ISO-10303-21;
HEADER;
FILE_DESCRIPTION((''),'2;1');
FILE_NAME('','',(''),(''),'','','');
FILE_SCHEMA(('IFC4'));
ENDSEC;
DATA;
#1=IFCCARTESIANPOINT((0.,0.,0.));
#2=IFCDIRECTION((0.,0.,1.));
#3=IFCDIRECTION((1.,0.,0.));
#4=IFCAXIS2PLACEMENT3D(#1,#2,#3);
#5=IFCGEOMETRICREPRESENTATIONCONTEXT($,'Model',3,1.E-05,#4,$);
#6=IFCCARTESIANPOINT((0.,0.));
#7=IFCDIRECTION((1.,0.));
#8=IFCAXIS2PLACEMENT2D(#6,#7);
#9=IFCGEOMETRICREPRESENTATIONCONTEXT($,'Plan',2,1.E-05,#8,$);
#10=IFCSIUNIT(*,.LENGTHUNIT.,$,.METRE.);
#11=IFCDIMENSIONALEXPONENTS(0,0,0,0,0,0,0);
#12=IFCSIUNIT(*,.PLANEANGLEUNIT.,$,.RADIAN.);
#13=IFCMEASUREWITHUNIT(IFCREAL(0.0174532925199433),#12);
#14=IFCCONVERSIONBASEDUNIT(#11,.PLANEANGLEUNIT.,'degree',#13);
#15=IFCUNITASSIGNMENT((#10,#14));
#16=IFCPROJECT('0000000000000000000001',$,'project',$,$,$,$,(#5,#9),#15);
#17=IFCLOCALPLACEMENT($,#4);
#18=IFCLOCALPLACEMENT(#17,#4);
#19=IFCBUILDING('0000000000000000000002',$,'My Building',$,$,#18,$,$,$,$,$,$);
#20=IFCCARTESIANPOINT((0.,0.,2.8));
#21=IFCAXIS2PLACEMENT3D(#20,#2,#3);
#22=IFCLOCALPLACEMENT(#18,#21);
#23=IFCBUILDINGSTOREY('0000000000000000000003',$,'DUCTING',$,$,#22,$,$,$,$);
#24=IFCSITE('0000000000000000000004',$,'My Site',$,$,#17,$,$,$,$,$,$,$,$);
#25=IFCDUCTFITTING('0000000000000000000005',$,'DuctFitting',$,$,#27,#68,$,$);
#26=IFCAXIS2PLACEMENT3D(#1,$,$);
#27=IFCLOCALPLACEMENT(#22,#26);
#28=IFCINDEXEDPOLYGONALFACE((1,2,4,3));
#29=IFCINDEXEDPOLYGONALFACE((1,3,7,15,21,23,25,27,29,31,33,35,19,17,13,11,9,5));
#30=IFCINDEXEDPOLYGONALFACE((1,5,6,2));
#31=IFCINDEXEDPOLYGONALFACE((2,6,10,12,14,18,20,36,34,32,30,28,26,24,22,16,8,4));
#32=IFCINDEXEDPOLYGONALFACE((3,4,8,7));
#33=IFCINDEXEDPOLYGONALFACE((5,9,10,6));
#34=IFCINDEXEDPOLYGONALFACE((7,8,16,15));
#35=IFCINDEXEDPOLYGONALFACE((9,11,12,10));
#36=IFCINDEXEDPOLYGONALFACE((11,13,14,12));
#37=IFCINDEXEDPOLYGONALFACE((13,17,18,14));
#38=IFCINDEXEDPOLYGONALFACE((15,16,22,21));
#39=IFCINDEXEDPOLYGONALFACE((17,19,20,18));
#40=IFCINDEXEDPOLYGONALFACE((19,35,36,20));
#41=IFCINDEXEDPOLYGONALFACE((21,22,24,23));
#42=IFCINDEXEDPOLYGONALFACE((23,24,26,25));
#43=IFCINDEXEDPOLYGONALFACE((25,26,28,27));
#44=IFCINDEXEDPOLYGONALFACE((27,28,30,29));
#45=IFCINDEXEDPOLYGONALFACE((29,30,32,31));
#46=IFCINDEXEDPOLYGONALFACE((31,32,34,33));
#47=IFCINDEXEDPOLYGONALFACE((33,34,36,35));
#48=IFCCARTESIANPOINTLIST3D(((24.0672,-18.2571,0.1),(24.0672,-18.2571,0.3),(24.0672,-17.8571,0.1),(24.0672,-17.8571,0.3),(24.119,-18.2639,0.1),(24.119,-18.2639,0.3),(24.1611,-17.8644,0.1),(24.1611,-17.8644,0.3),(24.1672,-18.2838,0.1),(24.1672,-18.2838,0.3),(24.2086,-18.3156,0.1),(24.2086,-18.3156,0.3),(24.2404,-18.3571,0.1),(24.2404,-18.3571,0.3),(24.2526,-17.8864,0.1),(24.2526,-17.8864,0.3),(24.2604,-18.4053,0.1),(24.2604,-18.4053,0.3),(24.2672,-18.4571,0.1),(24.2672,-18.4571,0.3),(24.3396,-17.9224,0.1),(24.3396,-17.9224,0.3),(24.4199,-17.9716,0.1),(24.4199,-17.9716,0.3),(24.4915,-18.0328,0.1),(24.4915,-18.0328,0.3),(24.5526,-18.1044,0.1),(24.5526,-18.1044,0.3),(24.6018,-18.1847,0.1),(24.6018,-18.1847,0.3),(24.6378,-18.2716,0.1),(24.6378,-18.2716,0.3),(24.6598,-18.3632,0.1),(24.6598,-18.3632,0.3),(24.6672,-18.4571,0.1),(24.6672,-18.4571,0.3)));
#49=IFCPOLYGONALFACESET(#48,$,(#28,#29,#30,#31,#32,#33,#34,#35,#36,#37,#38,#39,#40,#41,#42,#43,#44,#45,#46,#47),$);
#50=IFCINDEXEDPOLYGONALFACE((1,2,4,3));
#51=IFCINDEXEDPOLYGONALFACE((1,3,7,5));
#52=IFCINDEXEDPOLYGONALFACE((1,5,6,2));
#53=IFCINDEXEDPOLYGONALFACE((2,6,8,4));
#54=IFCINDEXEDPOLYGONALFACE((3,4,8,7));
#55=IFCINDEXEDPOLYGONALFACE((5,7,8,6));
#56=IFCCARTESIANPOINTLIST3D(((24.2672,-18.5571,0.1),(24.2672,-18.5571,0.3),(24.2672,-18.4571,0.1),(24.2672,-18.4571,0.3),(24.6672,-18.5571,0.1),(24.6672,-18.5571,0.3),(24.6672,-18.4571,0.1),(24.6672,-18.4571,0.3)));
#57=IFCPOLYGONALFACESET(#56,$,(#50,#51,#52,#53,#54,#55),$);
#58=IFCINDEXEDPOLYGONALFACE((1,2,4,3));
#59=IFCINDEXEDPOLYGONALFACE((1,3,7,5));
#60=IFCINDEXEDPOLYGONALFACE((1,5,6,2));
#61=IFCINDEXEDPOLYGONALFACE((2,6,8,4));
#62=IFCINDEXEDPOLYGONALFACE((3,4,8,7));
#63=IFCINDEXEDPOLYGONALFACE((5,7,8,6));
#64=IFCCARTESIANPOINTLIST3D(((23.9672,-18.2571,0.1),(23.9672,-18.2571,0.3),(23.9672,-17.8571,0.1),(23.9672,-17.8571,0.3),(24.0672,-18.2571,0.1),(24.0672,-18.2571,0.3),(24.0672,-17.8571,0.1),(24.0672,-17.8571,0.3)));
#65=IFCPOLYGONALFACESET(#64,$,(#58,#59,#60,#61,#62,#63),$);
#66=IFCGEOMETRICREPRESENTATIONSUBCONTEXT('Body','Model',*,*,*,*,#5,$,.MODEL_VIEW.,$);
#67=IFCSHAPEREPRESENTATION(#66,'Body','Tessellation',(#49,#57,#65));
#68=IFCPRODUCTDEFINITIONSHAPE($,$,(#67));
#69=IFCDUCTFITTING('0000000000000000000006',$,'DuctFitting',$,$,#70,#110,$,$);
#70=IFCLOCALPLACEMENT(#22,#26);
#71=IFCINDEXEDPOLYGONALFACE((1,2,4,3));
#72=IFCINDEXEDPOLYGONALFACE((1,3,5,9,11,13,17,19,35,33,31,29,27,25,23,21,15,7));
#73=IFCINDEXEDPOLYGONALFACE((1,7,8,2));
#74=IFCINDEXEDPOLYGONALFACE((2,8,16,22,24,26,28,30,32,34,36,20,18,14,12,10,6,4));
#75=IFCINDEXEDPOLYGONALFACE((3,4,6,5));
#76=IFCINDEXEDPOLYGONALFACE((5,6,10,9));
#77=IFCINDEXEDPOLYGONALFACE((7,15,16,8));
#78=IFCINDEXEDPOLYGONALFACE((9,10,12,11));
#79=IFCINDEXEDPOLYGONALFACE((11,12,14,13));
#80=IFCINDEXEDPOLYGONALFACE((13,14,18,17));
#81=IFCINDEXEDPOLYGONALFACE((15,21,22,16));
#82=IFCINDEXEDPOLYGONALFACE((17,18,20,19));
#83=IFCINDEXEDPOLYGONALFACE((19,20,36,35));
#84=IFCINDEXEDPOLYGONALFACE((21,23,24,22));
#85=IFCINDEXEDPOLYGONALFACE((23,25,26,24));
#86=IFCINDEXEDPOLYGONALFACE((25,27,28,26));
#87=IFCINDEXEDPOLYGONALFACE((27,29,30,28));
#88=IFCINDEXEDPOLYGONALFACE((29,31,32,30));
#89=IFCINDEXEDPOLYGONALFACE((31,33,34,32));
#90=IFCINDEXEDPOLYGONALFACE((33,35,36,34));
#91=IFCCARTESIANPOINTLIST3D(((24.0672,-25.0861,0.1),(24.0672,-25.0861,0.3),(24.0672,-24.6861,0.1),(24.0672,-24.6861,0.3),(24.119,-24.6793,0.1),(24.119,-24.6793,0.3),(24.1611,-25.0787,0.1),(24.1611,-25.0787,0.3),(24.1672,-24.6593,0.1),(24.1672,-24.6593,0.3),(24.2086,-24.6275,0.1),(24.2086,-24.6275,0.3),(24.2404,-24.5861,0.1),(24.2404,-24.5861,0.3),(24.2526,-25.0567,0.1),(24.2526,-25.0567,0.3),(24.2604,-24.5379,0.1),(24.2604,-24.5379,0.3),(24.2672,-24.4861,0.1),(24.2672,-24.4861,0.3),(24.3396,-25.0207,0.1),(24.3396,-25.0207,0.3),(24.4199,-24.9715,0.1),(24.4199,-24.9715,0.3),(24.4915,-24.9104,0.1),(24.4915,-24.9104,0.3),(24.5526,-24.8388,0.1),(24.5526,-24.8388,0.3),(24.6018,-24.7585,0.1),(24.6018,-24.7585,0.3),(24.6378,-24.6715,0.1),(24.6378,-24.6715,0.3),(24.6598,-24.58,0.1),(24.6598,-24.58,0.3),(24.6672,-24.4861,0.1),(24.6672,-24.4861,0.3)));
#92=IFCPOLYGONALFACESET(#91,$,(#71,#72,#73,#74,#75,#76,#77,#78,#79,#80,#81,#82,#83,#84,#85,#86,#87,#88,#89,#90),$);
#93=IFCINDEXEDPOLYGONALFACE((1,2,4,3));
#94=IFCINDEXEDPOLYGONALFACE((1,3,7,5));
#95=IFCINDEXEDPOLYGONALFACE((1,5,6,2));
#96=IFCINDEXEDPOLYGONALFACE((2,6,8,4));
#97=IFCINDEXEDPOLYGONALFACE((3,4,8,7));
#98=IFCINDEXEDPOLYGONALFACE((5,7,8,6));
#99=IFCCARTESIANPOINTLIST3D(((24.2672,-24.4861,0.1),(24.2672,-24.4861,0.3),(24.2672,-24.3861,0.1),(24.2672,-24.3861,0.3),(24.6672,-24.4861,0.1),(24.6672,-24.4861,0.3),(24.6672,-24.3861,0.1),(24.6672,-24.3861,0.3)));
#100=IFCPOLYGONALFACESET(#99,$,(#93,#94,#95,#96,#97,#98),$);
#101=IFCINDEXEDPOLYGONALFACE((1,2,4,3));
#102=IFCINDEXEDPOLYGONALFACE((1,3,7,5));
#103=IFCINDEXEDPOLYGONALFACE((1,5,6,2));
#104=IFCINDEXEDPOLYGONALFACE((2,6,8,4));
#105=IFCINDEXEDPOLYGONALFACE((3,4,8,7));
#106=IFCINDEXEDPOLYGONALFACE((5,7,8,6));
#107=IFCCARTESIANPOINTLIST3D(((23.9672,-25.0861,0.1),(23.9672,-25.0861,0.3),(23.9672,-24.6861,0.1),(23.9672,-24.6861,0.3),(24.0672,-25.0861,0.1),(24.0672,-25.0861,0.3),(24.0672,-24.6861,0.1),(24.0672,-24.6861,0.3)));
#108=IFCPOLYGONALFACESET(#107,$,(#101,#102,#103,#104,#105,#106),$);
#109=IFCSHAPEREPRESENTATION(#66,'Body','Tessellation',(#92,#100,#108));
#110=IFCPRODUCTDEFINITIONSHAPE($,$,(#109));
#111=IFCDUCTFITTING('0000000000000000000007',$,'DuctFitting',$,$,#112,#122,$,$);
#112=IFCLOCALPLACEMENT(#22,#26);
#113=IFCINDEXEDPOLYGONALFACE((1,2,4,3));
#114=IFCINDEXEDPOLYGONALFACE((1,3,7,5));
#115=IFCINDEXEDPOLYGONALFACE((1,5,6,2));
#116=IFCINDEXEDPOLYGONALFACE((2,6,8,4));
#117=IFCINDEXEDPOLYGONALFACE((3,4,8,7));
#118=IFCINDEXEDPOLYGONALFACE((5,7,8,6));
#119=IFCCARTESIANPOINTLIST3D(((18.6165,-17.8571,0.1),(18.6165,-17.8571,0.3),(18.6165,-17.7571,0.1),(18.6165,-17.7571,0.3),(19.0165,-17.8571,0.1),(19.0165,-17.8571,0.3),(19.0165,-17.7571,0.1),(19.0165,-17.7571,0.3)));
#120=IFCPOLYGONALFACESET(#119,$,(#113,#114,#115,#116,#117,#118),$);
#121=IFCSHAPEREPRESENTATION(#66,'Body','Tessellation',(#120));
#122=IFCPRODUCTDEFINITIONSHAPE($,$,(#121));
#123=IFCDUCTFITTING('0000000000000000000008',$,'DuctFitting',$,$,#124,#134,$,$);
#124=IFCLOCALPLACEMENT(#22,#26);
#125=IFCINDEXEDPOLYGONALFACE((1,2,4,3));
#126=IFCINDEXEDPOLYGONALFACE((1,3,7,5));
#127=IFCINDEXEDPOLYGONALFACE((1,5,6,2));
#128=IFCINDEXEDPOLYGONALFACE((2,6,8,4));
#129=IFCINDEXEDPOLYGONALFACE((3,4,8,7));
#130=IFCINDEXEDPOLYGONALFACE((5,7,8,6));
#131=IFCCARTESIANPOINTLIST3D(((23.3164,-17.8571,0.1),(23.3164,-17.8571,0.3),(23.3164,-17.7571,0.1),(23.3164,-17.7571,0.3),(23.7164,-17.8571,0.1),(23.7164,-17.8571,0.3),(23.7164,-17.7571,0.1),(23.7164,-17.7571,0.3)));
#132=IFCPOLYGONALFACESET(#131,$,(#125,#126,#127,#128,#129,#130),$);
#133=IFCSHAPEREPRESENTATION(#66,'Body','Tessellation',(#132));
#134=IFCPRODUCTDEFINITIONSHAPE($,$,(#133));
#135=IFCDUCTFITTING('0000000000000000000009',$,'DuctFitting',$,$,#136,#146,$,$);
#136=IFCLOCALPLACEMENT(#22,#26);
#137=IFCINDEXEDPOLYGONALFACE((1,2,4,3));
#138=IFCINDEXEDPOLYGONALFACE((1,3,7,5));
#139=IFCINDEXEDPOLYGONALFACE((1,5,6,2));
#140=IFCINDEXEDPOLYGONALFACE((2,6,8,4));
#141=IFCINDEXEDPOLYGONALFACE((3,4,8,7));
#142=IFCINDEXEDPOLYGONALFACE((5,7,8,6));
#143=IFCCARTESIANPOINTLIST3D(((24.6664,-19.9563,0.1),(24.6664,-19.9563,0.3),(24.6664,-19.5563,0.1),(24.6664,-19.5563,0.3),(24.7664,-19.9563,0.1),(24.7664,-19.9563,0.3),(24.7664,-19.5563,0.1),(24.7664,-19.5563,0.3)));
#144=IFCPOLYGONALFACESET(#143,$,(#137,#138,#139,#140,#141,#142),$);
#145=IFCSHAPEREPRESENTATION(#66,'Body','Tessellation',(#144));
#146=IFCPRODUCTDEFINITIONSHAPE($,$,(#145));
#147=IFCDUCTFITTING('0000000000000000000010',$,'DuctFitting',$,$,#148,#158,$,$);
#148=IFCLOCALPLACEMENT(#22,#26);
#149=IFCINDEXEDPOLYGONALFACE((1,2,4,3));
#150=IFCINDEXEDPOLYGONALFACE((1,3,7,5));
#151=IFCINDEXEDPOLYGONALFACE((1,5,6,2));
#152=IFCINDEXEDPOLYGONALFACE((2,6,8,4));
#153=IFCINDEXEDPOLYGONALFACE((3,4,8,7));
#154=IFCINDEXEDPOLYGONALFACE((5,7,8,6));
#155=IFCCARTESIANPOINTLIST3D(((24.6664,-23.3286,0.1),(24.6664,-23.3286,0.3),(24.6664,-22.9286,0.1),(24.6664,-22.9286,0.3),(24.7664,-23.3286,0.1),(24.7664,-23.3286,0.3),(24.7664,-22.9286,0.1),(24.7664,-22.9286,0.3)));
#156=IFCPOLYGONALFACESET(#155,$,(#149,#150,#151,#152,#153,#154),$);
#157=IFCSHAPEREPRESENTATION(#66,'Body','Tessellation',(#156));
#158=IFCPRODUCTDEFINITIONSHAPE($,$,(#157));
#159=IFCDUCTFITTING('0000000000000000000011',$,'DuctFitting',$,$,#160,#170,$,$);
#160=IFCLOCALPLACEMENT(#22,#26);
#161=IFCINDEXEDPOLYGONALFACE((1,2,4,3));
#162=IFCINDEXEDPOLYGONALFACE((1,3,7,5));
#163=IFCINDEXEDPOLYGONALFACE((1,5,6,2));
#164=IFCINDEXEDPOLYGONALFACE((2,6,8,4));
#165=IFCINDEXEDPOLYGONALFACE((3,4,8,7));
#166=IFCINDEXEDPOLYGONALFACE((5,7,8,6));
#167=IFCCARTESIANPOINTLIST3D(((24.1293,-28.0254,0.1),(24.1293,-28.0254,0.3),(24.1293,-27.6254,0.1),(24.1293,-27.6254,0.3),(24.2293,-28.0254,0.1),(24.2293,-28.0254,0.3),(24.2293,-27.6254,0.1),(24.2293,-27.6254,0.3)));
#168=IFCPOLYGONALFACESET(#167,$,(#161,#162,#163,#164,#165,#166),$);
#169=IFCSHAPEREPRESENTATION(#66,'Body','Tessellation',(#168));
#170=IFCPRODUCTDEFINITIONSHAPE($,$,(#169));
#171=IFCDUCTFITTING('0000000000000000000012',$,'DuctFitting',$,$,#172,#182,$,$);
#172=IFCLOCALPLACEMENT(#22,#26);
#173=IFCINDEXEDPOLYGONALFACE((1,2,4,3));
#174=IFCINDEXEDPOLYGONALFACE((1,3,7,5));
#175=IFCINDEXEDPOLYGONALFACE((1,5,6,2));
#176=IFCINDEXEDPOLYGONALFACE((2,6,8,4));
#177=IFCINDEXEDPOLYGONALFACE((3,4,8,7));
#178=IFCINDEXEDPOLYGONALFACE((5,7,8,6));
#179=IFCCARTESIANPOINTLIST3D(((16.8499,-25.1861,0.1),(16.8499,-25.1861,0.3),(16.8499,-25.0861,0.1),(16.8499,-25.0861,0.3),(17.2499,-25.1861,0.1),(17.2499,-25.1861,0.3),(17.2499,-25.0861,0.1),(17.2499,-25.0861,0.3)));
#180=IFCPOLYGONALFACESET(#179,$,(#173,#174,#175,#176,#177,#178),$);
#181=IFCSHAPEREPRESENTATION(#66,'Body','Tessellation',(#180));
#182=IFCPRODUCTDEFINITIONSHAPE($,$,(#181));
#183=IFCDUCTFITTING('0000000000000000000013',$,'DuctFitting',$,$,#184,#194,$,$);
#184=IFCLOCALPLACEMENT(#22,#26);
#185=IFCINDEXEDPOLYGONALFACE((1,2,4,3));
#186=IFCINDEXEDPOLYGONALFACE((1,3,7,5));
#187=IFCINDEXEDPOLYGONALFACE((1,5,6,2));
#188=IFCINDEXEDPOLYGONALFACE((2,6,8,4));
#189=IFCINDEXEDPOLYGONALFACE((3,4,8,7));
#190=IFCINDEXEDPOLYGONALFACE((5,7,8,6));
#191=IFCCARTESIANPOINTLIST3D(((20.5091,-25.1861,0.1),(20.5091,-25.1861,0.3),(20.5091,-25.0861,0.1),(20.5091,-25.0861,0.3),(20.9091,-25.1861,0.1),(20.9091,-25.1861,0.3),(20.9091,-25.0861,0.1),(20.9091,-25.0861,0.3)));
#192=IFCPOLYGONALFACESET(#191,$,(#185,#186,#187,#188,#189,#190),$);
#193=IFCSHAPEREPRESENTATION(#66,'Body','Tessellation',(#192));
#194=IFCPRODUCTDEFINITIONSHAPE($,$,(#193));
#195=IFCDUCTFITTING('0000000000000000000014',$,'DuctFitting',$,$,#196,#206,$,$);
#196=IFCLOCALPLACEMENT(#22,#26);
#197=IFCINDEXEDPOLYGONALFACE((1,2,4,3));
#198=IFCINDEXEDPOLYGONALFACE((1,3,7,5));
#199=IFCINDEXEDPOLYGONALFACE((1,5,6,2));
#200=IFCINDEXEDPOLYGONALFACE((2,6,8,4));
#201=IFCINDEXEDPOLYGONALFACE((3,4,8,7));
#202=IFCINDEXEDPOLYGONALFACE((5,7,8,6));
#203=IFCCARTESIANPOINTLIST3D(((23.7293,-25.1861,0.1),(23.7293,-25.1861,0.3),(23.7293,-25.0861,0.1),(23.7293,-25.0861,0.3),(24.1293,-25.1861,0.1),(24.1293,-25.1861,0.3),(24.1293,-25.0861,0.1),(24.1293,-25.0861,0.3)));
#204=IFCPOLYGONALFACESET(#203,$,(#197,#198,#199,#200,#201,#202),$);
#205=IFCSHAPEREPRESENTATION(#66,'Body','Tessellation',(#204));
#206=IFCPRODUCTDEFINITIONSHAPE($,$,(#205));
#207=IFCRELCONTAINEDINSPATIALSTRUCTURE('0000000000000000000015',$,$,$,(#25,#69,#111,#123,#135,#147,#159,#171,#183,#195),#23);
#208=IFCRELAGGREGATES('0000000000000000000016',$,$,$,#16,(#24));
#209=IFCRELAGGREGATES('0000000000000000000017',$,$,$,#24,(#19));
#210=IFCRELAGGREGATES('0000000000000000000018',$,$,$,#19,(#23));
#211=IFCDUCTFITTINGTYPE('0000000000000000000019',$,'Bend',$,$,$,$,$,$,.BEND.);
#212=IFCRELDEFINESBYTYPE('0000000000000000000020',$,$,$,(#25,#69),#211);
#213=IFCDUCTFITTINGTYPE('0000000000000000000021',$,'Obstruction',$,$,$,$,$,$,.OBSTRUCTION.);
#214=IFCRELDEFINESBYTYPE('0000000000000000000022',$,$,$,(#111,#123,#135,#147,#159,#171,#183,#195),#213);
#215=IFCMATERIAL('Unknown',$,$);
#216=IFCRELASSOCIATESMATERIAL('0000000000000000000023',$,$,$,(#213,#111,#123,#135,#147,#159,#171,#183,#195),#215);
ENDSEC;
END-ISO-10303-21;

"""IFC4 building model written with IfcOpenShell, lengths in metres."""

from ifc_helpers import new_model, entity, si_unit, converted_unit, frame, origin_with_axes, origin_2d_with_axis, place, context, subcontext, project, spatial, line, arc, indexed_curve, rectangle, outline, extrude, source, transform, mapped, material, material_profile, profile_set, profile_usage, type_object, type_shapes, element, save


model = new_model("IFC4")

# Units and contexts
model_context = context("Model", 3, precision=1e-05, world=origin_with_axes())
plan_context = context("Plan", 2, precision=1e-05, world=origin_2d_with_axis())
body_context = subcontext(model_context, "Body", "Model", "MODEL_VIEW")
ifc_project = project(units=[si_unit("LENGTHUNIT", "METRE"), converted_unit("PLANEANGLEUNIT", "degree", entity("IfcReal", 0.0174532925199433), si_unit("PLANEANGLEUNIT", "RADIAN"), dimensions=[0, 0, 0, 0, 0, 0, 0])], contexts=[model_context, plan_context])

# Site, building, storey
site_placement = place(None, origin_with_axes())
site = spatial("IfcSite", under=ifc_project, at=site_placement, Name="My Site")
building_placement = place(site_placement, origin_with_axes())
building = spatial("IfcBuilding", under=site, at=building_placement, Name="My Building")
storey_placement = place(building_placement, frame((0.0, 0.0, 2.8), z_axis=(0.0, 0.0, 1.0), x_axis=(1.0, 0.0, 0.0)))
storey = spatial("IfcBuildingStorey", under=building, at=storey_placement, Name="DUCTING")

# Shared definitions
ifc_material = material(Name="Unknown")

# Duct fittings
duct_fitting_type_1 = type_object("IfcDuctFittingType", Name="Bend", PredefinedType="BEND")
shared_shape = source(origin_with_axes(), body_context, "Body", "SweptSolid", [
    extrude(outline(indexed_curve([(0.2, 0.0), (0.2586, -0.1414), (0.4, -0.2), (0.4, -0.6), (-0.0243, -0.4243), (-0.2, 0.0)], segments=[arc(1, 2, 3), line(3, 4), arc(4, 5, 6), line(6, 1)])), frame((0.0, -0.1, -0.1), z_axis=(0.0, -1.0, 0.0), x_axis=(1.0, 0.0, 0.0)), (0.0, 0.0, -1.0), 0.2),
    extrude(rectangle(XDim=0.4, YDim=0.2), origin_with_axes(), (0.0, 0.0, -1.0), 0.1),
    extrude(rectangle(XDim=0.4, YDim=0.2), frame((0.4, 0.0, -0.5), z_axis=(1.0, 0.0, 0.0), x_axis=(0.0, 0.0, 1.0)), (0.0, 0.0, 1.0), 0.1),
])
type_shapes(duct_fitting_type_1, [shared_shape])
for number, where, z_axis, x_axis, name in (
    (1, (24.4672, -18.5571, 0.2), (0.0, -1.0, 0.0), (-1.0, 0.0, 0.0), "DuctFitting"),
    (2, (24.4672, -24.3861, 0.2), (0.0, 1.0, 0.0), (-1.0, 0.0, 0.0), "DuctFitting"),
):
    element("IfcDuctFitting", number, at=place(storey_placement, frame(where, z_axis=z_axis, x_axis=x_axis)), inside=storey, type_object=duct_fitting_type_1, Name=name, context=body_context, shape_type="MappedRepresentation", body=[
        mapped(shared_shape, transform((0.0, 0.0, 0.0), x_axis=(1.0, 0.0, 0.0), y_axis=(0.0, 1.0, 0.0), z_axis=(0.0, 0.0, 1.0), scale=1.0)),
    ])
ifc_material_profile_1 = material_profile(ifc_material, rectangle(XDim=0.4, YDim=0.2))
ifc_profile_set_1 = profile_set([ifc_material_profile_1])
ifc_profile_usage_1 = profile_usage(ifc_profile_set_1, cardinal=5)
duct_fitting_type_2 = type_object("IfcDuctFittingType", Name="Obstruction", PredefinedType="OBSTRUCTION", material=ifc_profile_set_1)
duct_fitting_1_placement = place(storey_placement, frame((18.8165, -17.8571, 0.2), z_axis=(0.0, 1.0, 0.0), x_axis=(-1.0, 0.0, 0.0)))
element("IfcDuctFitting", 3, at=duct_fitting_1_placement, inside=storey, type_object=duct_fitting_type_2, material=ifc_profile_usage_1, Name="DuctFitting", context=body_context, shape_type="SweptSolid", body=[
    extrude(rectangle(XDim=0.4, YDim=0.2), origin_with_axes(), (0.0, 0.0, 1.0), 0.1),
])
ifc_profile_usage_2 = profile_usage(ifc_profile_set_1, cardinal=5)
duct_fitting_2_placement = place(storey_placement, frame((23.5164, -17.8571, 0.2), z_axis=(0.0, 1.0, 0.0), x_axis=(-1.0, 0.0, 0.0)))
element("IfcDuctFitting", 4, at=duct_fitting_2_placement, inside=storey, type_object=duct_fitting_type_2, material=ifc_profile_usage_2, Name="DuctFitting", context=body_context, shape_type="SweptSolid", body=[
    extrude(rectangle(XDim=0.4, YDim=0.2), origin_with_axes(), (0.0, 0.0, 1.0), 0.1),
])
ifc_profile_usage_3 = profile_usage(ifc_profile_set_1, cardinal=5)
duct_fitting_3_placement = place(storey_placement, frame((24.6664, -19.7563, 0.2), z_axis=(1.0, 0.0, 0.0), x_axis=(0.0, 1.0, 0.0)))
element("IfcDuctFitting", 5, at=duct_fitting_3_placement, inside=storey, type_object=duct_fitting_type_2, material=ifc_profile_usage_3, Name="DuctFitting", context=body_context, shape_type="SweptSolid", body=[
    extrude(rectangle(XDim=0.4, YDim=0.2), origin_with_axes(), (0.0, 0.0, 1.0), 0.1),
])
ifc_profile_usage_4 = profile_usage(ifc_profile_set_1, cardinal=5)
duct_fitting_4_placement = place(storey_placement, frame((24.6664, -23.1286, 0.2), z_axis=(1.0, 0.0, 0.0), x_axis=(0.0, 1.0, 0.0)))
element("IfcDuctFitting", 6, at=duct_fitting_4_placement, inside=storey, type_object=duct_fitting_type_2, material=ifc_profile_usage_4, Name="DuctFitting", context=body_context, shape_type="SweptSolid", body=[
    extrude(rectangle(XDim=0.4, YDim=0.2), origin_with_axes(), (0.0, 0.0, 1.0), 0.1),
])
ifc_profile_usage_5 = profile_usage(ifc_profile_set_1, cardinal=5)
duct_fitting_5_placement = place(storey_placement, frame((24.1293, -27.8254, 0.2), z_axis=(1.0, 0.0, 0.0), x_axis=(0.0, 1.0, 0.0)))
element("IfcDuctFitting", 7, at=duct_fitting_5_placement, inside=storey, type_object=duct_fitting_type_2, material=ifc_profile_usage_5, Name="DuctFitting", context=body_context, shape_type="SweptSolid", body=[
    extrude(rectangle(XDim=0.4, YDim=0.2), origin_with_axes(), (0.0, 0.0, 1.0), 0.1),
])
ifc_profile_usage_6 = profile_usage(ifc_profile_set_1, cardinal=5)
duct_fitting_6_placement = place(storey_placement, frame((17.0499, -25.0861, 0.2), z_axis=(0.0, -1.0, 0.0), x_axis=(1.0, 0.0, 0.0)))
element("IfcDuctFitting", 8, at=duct_fitting_6_placement, inside=storey, type_object=duct_fitting_type_2, material=ifc_profile_usage_6, Name="DuctFitting", context=body_context, shape_type="SweptSolid", body=[
    extrude(rectangle(XDim=0.4, YDim=0.2), origin_with_axes(), (0.0, 0.0, 1.0), 0.1),
])
ifc_profile_usage_7 = profile_usage(ifc_profile_set_1, cardinal=5)
duct_fitting_7_placement = place(storey_placement, frame((20.7091, -25.0861, 0.2), z_axis=(0.0, -1.0, 0.0), x_axis=(1.0, 0.0, 0.0)))
element("IfcDuctFitting", 9, at=duct_fitting_7_placement, inside=storey, type_object=duct_fitting_type_2, material=ifc_profile_usage_7, Name="DuctFitting", context=body_context, shape_type="SweptSolid", body=[
    extrude(rectangle(XDim=0.4, YDim=0.2), origin_with_axes(), (0.0, 0.0, 1.0), 0.1),
])
ifc_profile_usage_8 = profile_usage(ifc_profile_set_1, cardinal=5)
duct_fitting_8_placement = place(storey_placement, frame((23.9293, -25.0861, 0.2), z_axis=(0.0, -1.0, 0.0), x_axis=(1.0, 0.0, 0.0)))
element("IfcDuctFitting", 10, at=duct_fitting_8_placement, inside=storey, type_object=duct_fitting_type_2, material=ifc_profile_usage_8, Name="DuctFitting", context=body_context, shape_type="SweptSolid", body=[
    extrude(rectangle(XDim=0.4, YDim=0.2), origin_with_axes(), (0.0, 0.0, 1.0), 0.1),
])

save(model, "model.ifc")
